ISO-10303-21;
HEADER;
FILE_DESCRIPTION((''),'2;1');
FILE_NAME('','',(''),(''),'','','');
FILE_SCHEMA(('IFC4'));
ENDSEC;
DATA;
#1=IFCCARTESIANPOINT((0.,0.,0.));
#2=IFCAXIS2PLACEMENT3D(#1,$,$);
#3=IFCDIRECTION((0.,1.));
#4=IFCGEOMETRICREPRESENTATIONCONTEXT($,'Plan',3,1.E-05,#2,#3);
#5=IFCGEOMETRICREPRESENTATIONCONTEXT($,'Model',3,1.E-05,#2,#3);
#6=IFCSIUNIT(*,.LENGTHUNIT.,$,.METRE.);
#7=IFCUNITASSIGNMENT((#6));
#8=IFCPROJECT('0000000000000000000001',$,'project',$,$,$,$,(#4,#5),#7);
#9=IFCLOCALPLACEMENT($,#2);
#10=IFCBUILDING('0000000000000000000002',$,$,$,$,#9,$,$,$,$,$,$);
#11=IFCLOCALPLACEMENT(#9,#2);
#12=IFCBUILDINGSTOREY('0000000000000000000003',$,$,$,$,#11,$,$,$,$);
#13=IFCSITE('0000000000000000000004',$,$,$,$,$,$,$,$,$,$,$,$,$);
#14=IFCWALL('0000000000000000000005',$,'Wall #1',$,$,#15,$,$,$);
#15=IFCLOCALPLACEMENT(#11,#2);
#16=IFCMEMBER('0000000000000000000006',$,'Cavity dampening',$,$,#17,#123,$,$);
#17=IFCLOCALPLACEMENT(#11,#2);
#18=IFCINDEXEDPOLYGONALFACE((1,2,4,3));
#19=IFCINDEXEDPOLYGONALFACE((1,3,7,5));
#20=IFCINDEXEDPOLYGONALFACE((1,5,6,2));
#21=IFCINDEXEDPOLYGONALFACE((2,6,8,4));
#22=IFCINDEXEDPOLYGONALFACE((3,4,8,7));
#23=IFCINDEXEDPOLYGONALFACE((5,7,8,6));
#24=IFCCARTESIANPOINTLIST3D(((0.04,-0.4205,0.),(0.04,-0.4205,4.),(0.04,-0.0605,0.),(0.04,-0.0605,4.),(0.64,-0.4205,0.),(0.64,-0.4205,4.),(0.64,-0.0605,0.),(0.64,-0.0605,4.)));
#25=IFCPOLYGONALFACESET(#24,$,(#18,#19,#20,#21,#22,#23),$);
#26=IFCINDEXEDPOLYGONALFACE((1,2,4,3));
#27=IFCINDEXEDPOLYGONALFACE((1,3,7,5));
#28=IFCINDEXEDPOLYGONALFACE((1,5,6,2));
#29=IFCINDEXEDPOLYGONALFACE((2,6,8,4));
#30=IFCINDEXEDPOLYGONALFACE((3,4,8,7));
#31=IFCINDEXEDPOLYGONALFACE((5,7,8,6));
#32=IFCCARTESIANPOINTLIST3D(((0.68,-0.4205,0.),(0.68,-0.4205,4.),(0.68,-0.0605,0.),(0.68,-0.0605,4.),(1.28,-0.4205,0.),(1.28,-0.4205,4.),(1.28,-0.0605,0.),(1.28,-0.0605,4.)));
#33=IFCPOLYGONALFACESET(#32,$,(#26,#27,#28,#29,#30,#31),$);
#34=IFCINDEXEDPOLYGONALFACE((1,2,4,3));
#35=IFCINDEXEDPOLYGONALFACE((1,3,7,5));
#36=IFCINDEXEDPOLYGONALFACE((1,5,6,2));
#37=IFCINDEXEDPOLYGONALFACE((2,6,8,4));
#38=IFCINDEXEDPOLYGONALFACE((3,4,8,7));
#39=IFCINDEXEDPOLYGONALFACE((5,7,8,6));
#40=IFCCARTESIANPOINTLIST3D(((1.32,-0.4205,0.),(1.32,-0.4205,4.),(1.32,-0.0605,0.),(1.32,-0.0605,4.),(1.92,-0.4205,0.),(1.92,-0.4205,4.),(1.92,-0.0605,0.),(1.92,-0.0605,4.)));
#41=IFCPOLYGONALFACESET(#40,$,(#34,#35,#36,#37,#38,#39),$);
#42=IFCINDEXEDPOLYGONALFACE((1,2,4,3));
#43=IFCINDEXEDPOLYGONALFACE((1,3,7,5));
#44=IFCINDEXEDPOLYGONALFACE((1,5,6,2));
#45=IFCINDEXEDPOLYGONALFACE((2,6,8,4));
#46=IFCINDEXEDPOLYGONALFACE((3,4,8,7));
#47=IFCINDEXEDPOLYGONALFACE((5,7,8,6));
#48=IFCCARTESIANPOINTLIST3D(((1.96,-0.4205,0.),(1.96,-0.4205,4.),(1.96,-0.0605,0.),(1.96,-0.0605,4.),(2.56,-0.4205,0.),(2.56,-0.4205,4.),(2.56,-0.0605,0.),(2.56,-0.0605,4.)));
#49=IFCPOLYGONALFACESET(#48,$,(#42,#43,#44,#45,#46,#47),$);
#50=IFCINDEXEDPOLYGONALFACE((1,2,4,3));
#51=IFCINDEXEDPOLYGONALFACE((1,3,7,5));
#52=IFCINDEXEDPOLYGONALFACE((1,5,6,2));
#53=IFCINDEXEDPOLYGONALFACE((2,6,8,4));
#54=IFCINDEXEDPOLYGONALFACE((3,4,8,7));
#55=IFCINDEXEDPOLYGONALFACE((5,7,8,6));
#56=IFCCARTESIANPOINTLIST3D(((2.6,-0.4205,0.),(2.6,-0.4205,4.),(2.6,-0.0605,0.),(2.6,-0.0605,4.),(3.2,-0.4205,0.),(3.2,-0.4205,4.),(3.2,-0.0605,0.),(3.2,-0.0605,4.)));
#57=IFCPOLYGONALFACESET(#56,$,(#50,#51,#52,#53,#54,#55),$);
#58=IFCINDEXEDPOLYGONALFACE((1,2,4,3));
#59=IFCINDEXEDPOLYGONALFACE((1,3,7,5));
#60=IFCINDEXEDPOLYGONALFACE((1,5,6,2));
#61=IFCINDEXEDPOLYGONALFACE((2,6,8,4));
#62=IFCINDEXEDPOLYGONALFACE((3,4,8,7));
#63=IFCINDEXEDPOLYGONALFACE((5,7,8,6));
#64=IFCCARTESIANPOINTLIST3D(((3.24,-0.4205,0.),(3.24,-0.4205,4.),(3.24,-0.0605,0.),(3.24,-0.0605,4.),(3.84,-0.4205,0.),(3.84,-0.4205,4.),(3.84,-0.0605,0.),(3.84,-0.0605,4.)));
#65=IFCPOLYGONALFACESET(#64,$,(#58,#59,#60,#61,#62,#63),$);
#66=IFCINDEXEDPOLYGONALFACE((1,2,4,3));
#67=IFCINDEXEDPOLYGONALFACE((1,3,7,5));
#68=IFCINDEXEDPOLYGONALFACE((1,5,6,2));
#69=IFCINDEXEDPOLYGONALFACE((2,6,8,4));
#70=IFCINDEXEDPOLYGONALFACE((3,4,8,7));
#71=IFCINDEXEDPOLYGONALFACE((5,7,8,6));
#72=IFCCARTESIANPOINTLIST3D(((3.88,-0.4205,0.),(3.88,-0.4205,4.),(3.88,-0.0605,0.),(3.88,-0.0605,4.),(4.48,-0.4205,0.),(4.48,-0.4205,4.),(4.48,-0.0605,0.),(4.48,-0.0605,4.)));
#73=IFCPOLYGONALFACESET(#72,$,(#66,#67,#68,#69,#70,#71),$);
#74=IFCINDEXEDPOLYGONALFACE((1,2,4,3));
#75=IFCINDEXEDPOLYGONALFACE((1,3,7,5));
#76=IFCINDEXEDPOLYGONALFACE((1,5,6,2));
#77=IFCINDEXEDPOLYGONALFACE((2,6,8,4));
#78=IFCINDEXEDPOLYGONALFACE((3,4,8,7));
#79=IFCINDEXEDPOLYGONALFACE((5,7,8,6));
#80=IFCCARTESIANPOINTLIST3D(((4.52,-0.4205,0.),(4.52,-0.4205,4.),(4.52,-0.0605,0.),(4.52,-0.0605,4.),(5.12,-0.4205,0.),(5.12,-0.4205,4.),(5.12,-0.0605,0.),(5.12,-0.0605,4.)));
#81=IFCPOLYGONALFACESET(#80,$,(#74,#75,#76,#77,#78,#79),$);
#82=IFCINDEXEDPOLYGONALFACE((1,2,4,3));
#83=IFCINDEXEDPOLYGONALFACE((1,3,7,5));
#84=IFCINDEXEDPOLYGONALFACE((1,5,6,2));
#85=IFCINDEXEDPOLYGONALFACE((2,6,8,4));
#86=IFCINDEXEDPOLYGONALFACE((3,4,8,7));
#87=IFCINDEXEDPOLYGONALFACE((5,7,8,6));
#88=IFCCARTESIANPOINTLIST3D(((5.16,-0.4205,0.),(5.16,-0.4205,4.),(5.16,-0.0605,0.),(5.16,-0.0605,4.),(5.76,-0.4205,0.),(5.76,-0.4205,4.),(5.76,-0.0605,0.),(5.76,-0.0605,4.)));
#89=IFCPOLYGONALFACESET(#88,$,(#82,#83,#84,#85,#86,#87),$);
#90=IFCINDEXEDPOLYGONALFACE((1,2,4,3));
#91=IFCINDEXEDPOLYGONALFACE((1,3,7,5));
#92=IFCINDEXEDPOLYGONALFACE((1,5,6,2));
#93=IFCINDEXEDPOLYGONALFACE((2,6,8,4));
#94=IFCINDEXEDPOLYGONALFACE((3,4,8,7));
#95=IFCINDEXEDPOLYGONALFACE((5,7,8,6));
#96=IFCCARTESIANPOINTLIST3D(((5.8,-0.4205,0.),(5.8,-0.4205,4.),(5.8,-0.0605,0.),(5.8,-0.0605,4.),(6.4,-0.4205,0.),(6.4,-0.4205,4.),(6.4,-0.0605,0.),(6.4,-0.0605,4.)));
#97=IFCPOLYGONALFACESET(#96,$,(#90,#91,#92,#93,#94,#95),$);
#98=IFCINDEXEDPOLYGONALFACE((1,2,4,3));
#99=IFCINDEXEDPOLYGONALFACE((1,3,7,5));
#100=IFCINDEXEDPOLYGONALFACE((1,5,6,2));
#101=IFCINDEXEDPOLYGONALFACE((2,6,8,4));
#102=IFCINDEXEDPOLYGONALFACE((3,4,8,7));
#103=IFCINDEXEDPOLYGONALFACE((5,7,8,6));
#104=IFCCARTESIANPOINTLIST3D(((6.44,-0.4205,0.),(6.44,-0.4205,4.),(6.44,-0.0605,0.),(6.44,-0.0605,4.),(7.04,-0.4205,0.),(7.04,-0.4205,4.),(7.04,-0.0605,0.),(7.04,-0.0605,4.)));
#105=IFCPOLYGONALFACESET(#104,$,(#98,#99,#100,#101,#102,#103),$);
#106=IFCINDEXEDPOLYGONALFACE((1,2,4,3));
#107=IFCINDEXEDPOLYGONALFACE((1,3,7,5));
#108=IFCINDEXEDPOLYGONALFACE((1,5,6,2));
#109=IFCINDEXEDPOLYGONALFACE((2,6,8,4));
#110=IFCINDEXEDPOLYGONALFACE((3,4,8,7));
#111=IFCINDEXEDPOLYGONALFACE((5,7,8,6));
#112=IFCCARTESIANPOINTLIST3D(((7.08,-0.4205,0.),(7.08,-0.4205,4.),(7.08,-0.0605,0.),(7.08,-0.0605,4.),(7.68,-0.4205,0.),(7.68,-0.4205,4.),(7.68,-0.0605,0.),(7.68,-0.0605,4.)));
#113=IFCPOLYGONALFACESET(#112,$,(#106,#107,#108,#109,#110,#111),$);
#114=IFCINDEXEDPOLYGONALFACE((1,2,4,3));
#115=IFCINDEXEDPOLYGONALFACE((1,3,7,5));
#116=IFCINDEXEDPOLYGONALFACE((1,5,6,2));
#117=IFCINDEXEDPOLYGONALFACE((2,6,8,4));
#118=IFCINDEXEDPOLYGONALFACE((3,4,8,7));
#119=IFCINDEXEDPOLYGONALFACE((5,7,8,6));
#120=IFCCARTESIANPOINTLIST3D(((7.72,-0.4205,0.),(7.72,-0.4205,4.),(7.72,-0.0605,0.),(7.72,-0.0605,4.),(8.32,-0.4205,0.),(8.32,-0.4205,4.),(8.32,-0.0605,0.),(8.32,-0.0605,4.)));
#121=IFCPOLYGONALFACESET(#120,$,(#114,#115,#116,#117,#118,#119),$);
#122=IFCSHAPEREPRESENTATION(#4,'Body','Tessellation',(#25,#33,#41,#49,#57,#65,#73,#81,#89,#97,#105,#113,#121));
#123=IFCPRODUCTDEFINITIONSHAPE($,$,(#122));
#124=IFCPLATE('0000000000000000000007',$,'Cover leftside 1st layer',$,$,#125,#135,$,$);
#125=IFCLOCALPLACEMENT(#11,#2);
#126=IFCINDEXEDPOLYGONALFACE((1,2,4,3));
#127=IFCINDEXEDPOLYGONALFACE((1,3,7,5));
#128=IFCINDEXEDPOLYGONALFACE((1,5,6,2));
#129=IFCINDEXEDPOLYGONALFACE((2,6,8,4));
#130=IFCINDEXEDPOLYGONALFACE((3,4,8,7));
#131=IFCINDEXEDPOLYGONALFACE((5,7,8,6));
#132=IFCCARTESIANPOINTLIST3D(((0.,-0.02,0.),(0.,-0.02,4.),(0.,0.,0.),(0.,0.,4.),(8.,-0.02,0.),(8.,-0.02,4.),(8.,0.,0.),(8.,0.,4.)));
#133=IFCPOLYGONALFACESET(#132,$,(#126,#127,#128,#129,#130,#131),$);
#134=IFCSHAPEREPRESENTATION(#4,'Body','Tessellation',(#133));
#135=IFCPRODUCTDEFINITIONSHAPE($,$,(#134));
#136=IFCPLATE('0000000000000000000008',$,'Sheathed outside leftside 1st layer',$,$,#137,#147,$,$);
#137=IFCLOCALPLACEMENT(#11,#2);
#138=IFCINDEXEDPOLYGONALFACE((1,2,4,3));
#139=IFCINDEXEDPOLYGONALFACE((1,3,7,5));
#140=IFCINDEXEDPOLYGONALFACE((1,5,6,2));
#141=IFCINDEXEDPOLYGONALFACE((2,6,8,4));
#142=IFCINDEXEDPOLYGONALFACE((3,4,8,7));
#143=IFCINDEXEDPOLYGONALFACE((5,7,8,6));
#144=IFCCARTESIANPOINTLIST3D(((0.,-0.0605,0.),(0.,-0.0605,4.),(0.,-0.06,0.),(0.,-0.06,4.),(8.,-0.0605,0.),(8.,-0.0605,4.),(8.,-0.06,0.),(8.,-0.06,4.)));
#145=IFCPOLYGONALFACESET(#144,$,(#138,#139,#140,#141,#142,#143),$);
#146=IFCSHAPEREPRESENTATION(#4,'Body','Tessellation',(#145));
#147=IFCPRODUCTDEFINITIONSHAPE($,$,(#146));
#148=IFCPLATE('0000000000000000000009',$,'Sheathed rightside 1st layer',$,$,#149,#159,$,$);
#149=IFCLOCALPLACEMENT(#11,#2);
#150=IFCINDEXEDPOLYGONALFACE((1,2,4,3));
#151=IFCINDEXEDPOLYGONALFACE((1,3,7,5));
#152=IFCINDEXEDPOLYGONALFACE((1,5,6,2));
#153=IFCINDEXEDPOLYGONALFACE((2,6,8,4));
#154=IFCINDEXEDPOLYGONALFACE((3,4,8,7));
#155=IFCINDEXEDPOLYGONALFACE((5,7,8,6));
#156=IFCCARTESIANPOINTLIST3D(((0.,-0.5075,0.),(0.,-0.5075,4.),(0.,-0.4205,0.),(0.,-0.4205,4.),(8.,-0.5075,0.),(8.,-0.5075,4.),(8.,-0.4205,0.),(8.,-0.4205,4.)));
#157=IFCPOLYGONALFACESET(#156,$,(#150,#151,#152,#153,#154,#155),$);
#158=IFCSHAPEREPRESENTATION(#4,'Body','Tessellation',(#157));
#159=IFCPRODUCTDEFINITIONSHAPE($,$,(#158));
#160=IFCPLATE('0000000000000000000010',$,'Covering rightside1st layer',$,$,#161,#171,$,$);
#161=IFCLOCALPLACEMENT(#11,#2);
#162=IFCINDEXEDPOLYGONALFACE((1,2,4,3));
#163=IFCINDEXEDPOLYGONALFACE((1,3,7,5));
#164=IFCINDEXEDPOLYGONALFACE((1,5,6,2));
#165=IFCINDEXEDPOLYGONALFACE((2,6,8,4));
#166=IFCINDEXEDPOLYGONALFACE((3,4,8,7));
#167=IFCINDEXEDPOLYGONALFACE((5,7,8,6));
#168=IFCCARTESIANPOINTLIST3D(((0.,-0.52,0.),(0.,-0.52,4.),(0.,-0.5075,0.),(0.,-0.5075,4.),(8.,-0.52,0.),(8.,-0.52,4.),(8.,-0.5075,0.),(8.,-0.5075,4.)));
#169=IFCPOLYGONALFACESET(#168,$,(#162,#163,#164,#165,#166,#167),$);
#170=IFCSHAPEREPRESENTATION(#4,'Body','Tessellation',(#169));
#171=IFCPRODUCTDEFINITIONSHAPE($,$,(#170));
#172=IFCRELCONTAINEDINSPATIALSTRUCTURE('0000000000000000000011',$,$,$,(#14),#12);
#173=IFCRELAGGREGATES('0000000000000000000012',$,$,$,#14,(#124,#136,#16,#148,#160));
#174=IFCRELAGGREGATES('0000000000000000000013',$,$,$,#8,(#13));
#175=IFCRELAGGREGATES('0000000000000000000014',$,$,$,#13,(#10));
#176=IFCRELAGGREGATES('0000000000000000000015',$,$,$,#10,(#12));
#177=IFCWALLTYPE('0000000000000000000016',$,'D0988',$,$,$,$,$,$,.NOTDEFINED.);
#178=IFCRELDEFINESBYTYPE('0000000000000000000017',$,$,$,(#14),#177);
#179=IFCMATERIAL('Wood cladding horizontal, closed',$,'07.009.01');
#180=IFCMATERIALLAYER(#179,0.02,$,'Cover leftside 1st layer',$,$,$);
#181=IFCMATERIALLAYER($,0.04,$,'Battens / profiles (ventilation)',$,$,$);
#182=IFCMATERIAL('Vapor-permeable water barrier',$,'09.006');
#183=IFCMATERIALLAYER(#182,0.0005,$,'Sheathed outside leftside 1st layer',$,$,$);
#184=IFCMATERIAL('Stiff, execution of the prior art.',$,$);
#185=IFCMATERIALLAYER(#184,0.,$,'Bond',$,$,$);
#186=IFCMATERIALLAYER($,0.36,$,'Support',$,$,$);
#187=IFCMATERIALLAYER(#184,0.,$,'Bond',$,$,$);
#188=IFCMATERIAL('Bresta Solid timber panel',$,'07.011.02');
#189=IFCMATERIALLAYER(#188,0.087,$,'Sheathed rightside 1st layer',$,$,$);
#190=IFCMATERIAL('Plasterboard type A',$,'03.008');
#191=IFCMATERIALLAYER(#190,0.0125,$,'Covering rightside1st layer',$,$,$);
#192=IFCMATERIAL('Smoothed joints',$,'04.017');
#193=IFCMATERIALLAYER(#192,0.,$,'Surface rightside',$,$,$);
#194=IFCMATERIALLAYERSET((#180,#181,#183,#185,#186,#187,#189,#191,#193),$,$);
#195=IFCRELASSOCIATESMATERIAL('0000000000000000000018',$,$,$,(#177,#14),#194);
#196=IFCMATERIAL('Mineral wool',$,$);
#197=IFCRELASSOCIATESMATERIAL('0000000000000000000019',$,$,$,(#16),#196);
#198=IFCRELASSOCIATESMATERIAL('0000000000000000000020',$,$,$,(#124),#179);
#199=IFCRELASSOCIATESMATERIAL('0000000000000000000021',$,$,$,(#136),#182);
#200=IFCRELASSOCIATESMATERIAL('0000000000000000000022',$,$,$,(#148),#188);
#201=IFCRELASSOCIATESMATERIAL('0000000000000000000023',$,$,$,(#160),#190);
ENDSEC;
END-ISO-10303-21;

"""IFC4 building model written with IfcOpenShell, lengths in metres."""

from ifc_helpers import new_model, si_unit, direction, frame, frame_2d, origin, origin_with_axes, place, context, project, spatial, rectangle, extrude, material, layer, layer_set, type_object, element, aggregate, save


model = new_model("IFC4")

# Units and contexts
plan_context = context("Plan", 3, precision=1e-05, world=origin(), true_north=direction((0.0, 1.0)))
model_context = context("Model", 3, precision=1e-05, world=origin(), true_north=direction((0.0, 1.0)))
ifc_project = project(units=[si_unit("LENGTHUNIT", "METRE")], contexts=[plan_context, model_context])

# Site, building, storey
site = spatial("IfcSite", under=ifc_project)
building_placement = place(None, origin())
building = spatial("IfcBuilding", under=site, at=building_placement)
storey_placement = place(building_placement, origin())
storey = spatial("IfcBuildingStorey", under=building, at=storey_placement)

# Wall, member, plates
ifc_material_1 = material(Name="Wood cladding horizontal, closed", Category="07.009.01")
ifc_layer_1 = layer(ifc_material_1, 0.02, Name="Cover leftside 1st layer")
ifc_layer_2 = layer(None, 0.04, Name="Battens / profiles (ventilation)")
ifc_material_2 = material(Name="Vapor-permeable water barrier", Category="09.006")
ifc_layer_3 = layer(ifc_material_2, 0.0005, Name="Sheathed outside leftside 1st layer")
ifc_material_3 = material(Name="Stiff, execution of the prior art.")
ifc_layer_4 = layer(ifc_material_3, 0.0, Name="Bond")
ifc_layer_5 = layer(None, 0.36, Name="Support")
ifc_layer_6 = layer(ifc_material_3, 0.0, Name="Bond")
ifc_material_4 = material(Name="Bresta Solid timber panel", Category="07.011.02")
ifc_layer_7 = layer(ifc_material_4, 0.087, Name="Sheathed rightside 1st layer")
ifc_material_5 = material(Name="Plasterboard type A", Category="03.008")
ifc_layer_8 = layer(ifc_material_5, 0.0125, Name="Covering rightside1st layer")
ifc_material_6 = material(Name="Smoothed joints", Category="04.017")
ifc_layer_9 = layer(ifc_material_6, 0.0, Name="Surface rightside")
ifc_layer_set = layer_set([ifc_layer_1, ifc_layer_2, ifc_layer_3, ifc_layer_4, ifc_layer_5, ifc_layer_6, ifc_layer_7, ifc_layer_8, ifc_layer_9])
wall_type = type_object("IfcWallType", Name="D0988", PredefinedType="NOTDEFINED", material=ifc_layer_set)
wall_placement = place(None, frame((0.0, 0.0, 0.0), z_axis=(0.0, -1.0, 0.0), x_axis=(1.0, 0.0, 0.0)))
wall = element("IfcWall", 1, at=wall_placement, inside=storey, type_object=wall_type, material=ifc_layer_set, Name="Wall #1")
ifc_material_7 = material(Name="Mineral wool")
member_1_placement = place(wall_placement, origin())
member_1 = element("IfcMember", 2, at=member_1_placement, material=ifc_material_7, Name="Cavity dampening", context=plan_context, shape_type="SweptSolid", body=[
    extrude(rectangle(XDim=0.6, YDim=0.36, at=frame_2d((0.3, 0.18), x_axis=(1.0, 0.0))), frame((0.04, 4.0, 0.0605), z_axis=(0.0, -1.0, 0.0), x_axis=(1.0, 0.0, 0.0)), (0.0, 0.0, 1.0), 4.0),
    extrude(rectangle(XDim=0.6, YDim=0.36, at=frame_2d((0.3, 0.18), x_axis=(1.0, 0.0))), frame((0.68, 4.0, 0.0605), z_axis=(0.0, -1.0, 0.0), x_axis=(1.0, 0.0, 0.0)), (0.0, 0.0, 1.0), 4.0),
    extrude(rectangle(XDim=0.6, YDim=0.36, at=frame_2d((0.3, 0.18), x_axis=(1.0, 0.0))), frame((1.32, 4.0, 0.0605), z_axis=(0.0, -1.0, 0.0), x_axis=(1.0, 0.0, 0.0)), (0.0, 0.0, 1.0), 4.0),
    extrude(rectangle(XDim=0.6, YDim=0.36, at=frame_2d((0.3, 0.18), x_axis=(1.0, 0.0))), frame((1.96, 4.0, 0.0605), z_axis=(0.0, -1.0, 0.0), x_axis=(1.0, 0.0, 0.0)), (0.0, 0.0, 1.0), 4.0),
    extrude(rectangle(XDim=0.6, YDim=0.36, at=frame_2d((0.3, 0.18), x_axis=(1.0, 0.0))), frame((2.6, 4.0, 0.0605), z_axis=(0.0, -1.0, 0.0), x_axis=(1.0, 0.0, 0.0)), (0.0, 0.0, 1.0), 4.0),
    extrude(rectangle(XDim=0.6, YDim=0.36, at=frame_2d((0.3, 0.18), x_axis=(1.0, 0.0))), frame((3.24, 4.0, 0.0605), z_axis=(0.0, -1.0, 0.0), x_axis=(1.0, 0.0, 0.0)), (0.0, 0.0, 1.0), 4.0),
    extrude(rectangle(XDim=0.6, YDim=0.36, at=frame_2d((0.3, 0.18), x_axis=(1.0, 0.0))), frame((3.88, 4.0, 0.0605), z_axis=(0.0, -1.0, 0.0), x_axis=(1.0, 0.0, 0.0)), (0.0, 0.0, 1.0), 4.0),
    extrude(rectangle(XDim=0.6, YDim=0.36, at=frame_2d((0.3, 0.18), x_axis=(1.0, 0.0))), frame((4.52, 4.0, 0.0605), z_axis=(0.0, -1.0, 0.0), x_axis=(1.0, 0.0, 0.0)), (0.0, 0.0, 1.0), 4.0),
    extrude(rectangle(XDim=0.6, YDim=0.36, at=frame_2d((0.3, 0.18), x_axis=(1.0, 0.0))), frame((5.16, 4.0, 0.0605), z_axis=(0.0, -1.0, 0.0), x_axis=(1.0, 0.0, 0.0)), (0.0, 0.0, 1.0), 4.0),
    extrude(rectangle(XDim=0.6, YDim=0.36, at=frame_2d((0.3, 0.18), x_axis=(1.0, 0.0))), frame((5.8, 4.0, 0.0605), z_axis=(0.0, -1.0, 0.0), x_axis=(1.0, 0.0, 0.0)), (0.0, 0.0, 1.0), 4.0),
    extrude(rectangle(XDim=0.6, YDim=0.36, at=frame_2d((0.3, 0.18), x_axis=(1.0, 0.0))), frame((6.44, 4.0, 0.0605), z_axis=(0.0, -1.0, 0.0), x_axis=(1.0, 0.0, 0.0)), (0.0, 0.0, 1.0), 4.0),
    extrude(rectangle(XDim=0.6, YDim=0.36, at=frame_2d((0.3, 0.18), x_axis=(1.0, 0.0))), frame((7.08, 4.0, 0.0605), z_axis=(0.0, -1.0, 0.0), x_axis=(1.0, 0.0, 0.0)), (0.0, 0.0, 1.0), 4.0),
    extrude(rectangle(XDim=0.6, YDim=0.36, at=frame_2d((0.3, 0.18), x_axis=(1.0, 0.0))), frame((7.72, 4.0, 0.0605), z_axis=(0.0, -1.0, 0.0), x_axis=(1.0, 0.0, 0.0)), (0.0, 0.0, 1.0), 4.0),
])
plate_1_placement = place(wall_placement, origin())
plate_1 = element("IfcPlate", 3, at=plate_1_placement, material=ifc_material_1, Name="Cover leftside 1st layer", context=plan_context, shape_type="SweptSolid", body=[
    extrude(rectangle(XDim=8.0, YDim=4.0, at=frame_2d((4.0, 2.0), x_axis=(1.0, 0.0))), origin_with_axes(), (0.0, 0.0, 1.0), 0.02),
])
plate_2_placement = place(wall_placement, origin())
plate_2 = element("IfcPlate", 4, at=plate_2_placement, material=ifc_material_2, Name="Sheathed outside leftside 1st layer", context=plan_context, shape_type="SweptSolid", body=[
    extrude(rectangle(XDim=8.0, YDim=4.0, at=frame_2d((4.0, 2.0), x_axis=(1.0, 0.0))), frame((0.0, 0.0, 0.06), z_axis=(0.0, 0.0, 1.0), x_axis=(1.0, 0.0, 0.0)), (0.0, 0.0, 1.0), 0.0005),
])
plate_3_placement = place(wall_placement, origin())
plate_3 = element("IfcPlate", 5, at=plate_3_placement, material=ifc_material_4, Name="Sheathed rightside 1st layer", context=plan_context, shape_type="SweptSolid", body=[
    extrude(rectangle(XDim=8.0, YDim=4.0, at=frame_2d((4.0, 2.0), x_axis=(1.0, 0.0))), frame((0.0, 0.0, 0.4205), z_axis=(0.0, 0.0, 1.0), x_axis=(1.0, 0.0, 0.0)), (0.0, 0.0, 1.0), 0.087),
])
plate_4_placement = place(wall_placement, origin())
plate_4 = element("IfcPlate", 6, at=plate_4_placement, material=ifc_material_5, Name="Covering rightside1st layer", context=plan_context, shape_type="SweptSolid", body=[
    extrude(rectangle(XDim=8.0, YDim=4.0, at=frame_2d((4.0, 2.0), x_axis=(1.0, 0.0))), frame((0.0, 0.0, 0.5075), z_axis=(0.0, 0.0, 1.0), x_axis=(1.0, 0.0, 0.0)), (0.0, 0.0, 1.0), 0.0125),
])
aggregate(wall, [plate_1, plate_2, member_1, plate_3, plate_4])

save(model, "model.ifc")
